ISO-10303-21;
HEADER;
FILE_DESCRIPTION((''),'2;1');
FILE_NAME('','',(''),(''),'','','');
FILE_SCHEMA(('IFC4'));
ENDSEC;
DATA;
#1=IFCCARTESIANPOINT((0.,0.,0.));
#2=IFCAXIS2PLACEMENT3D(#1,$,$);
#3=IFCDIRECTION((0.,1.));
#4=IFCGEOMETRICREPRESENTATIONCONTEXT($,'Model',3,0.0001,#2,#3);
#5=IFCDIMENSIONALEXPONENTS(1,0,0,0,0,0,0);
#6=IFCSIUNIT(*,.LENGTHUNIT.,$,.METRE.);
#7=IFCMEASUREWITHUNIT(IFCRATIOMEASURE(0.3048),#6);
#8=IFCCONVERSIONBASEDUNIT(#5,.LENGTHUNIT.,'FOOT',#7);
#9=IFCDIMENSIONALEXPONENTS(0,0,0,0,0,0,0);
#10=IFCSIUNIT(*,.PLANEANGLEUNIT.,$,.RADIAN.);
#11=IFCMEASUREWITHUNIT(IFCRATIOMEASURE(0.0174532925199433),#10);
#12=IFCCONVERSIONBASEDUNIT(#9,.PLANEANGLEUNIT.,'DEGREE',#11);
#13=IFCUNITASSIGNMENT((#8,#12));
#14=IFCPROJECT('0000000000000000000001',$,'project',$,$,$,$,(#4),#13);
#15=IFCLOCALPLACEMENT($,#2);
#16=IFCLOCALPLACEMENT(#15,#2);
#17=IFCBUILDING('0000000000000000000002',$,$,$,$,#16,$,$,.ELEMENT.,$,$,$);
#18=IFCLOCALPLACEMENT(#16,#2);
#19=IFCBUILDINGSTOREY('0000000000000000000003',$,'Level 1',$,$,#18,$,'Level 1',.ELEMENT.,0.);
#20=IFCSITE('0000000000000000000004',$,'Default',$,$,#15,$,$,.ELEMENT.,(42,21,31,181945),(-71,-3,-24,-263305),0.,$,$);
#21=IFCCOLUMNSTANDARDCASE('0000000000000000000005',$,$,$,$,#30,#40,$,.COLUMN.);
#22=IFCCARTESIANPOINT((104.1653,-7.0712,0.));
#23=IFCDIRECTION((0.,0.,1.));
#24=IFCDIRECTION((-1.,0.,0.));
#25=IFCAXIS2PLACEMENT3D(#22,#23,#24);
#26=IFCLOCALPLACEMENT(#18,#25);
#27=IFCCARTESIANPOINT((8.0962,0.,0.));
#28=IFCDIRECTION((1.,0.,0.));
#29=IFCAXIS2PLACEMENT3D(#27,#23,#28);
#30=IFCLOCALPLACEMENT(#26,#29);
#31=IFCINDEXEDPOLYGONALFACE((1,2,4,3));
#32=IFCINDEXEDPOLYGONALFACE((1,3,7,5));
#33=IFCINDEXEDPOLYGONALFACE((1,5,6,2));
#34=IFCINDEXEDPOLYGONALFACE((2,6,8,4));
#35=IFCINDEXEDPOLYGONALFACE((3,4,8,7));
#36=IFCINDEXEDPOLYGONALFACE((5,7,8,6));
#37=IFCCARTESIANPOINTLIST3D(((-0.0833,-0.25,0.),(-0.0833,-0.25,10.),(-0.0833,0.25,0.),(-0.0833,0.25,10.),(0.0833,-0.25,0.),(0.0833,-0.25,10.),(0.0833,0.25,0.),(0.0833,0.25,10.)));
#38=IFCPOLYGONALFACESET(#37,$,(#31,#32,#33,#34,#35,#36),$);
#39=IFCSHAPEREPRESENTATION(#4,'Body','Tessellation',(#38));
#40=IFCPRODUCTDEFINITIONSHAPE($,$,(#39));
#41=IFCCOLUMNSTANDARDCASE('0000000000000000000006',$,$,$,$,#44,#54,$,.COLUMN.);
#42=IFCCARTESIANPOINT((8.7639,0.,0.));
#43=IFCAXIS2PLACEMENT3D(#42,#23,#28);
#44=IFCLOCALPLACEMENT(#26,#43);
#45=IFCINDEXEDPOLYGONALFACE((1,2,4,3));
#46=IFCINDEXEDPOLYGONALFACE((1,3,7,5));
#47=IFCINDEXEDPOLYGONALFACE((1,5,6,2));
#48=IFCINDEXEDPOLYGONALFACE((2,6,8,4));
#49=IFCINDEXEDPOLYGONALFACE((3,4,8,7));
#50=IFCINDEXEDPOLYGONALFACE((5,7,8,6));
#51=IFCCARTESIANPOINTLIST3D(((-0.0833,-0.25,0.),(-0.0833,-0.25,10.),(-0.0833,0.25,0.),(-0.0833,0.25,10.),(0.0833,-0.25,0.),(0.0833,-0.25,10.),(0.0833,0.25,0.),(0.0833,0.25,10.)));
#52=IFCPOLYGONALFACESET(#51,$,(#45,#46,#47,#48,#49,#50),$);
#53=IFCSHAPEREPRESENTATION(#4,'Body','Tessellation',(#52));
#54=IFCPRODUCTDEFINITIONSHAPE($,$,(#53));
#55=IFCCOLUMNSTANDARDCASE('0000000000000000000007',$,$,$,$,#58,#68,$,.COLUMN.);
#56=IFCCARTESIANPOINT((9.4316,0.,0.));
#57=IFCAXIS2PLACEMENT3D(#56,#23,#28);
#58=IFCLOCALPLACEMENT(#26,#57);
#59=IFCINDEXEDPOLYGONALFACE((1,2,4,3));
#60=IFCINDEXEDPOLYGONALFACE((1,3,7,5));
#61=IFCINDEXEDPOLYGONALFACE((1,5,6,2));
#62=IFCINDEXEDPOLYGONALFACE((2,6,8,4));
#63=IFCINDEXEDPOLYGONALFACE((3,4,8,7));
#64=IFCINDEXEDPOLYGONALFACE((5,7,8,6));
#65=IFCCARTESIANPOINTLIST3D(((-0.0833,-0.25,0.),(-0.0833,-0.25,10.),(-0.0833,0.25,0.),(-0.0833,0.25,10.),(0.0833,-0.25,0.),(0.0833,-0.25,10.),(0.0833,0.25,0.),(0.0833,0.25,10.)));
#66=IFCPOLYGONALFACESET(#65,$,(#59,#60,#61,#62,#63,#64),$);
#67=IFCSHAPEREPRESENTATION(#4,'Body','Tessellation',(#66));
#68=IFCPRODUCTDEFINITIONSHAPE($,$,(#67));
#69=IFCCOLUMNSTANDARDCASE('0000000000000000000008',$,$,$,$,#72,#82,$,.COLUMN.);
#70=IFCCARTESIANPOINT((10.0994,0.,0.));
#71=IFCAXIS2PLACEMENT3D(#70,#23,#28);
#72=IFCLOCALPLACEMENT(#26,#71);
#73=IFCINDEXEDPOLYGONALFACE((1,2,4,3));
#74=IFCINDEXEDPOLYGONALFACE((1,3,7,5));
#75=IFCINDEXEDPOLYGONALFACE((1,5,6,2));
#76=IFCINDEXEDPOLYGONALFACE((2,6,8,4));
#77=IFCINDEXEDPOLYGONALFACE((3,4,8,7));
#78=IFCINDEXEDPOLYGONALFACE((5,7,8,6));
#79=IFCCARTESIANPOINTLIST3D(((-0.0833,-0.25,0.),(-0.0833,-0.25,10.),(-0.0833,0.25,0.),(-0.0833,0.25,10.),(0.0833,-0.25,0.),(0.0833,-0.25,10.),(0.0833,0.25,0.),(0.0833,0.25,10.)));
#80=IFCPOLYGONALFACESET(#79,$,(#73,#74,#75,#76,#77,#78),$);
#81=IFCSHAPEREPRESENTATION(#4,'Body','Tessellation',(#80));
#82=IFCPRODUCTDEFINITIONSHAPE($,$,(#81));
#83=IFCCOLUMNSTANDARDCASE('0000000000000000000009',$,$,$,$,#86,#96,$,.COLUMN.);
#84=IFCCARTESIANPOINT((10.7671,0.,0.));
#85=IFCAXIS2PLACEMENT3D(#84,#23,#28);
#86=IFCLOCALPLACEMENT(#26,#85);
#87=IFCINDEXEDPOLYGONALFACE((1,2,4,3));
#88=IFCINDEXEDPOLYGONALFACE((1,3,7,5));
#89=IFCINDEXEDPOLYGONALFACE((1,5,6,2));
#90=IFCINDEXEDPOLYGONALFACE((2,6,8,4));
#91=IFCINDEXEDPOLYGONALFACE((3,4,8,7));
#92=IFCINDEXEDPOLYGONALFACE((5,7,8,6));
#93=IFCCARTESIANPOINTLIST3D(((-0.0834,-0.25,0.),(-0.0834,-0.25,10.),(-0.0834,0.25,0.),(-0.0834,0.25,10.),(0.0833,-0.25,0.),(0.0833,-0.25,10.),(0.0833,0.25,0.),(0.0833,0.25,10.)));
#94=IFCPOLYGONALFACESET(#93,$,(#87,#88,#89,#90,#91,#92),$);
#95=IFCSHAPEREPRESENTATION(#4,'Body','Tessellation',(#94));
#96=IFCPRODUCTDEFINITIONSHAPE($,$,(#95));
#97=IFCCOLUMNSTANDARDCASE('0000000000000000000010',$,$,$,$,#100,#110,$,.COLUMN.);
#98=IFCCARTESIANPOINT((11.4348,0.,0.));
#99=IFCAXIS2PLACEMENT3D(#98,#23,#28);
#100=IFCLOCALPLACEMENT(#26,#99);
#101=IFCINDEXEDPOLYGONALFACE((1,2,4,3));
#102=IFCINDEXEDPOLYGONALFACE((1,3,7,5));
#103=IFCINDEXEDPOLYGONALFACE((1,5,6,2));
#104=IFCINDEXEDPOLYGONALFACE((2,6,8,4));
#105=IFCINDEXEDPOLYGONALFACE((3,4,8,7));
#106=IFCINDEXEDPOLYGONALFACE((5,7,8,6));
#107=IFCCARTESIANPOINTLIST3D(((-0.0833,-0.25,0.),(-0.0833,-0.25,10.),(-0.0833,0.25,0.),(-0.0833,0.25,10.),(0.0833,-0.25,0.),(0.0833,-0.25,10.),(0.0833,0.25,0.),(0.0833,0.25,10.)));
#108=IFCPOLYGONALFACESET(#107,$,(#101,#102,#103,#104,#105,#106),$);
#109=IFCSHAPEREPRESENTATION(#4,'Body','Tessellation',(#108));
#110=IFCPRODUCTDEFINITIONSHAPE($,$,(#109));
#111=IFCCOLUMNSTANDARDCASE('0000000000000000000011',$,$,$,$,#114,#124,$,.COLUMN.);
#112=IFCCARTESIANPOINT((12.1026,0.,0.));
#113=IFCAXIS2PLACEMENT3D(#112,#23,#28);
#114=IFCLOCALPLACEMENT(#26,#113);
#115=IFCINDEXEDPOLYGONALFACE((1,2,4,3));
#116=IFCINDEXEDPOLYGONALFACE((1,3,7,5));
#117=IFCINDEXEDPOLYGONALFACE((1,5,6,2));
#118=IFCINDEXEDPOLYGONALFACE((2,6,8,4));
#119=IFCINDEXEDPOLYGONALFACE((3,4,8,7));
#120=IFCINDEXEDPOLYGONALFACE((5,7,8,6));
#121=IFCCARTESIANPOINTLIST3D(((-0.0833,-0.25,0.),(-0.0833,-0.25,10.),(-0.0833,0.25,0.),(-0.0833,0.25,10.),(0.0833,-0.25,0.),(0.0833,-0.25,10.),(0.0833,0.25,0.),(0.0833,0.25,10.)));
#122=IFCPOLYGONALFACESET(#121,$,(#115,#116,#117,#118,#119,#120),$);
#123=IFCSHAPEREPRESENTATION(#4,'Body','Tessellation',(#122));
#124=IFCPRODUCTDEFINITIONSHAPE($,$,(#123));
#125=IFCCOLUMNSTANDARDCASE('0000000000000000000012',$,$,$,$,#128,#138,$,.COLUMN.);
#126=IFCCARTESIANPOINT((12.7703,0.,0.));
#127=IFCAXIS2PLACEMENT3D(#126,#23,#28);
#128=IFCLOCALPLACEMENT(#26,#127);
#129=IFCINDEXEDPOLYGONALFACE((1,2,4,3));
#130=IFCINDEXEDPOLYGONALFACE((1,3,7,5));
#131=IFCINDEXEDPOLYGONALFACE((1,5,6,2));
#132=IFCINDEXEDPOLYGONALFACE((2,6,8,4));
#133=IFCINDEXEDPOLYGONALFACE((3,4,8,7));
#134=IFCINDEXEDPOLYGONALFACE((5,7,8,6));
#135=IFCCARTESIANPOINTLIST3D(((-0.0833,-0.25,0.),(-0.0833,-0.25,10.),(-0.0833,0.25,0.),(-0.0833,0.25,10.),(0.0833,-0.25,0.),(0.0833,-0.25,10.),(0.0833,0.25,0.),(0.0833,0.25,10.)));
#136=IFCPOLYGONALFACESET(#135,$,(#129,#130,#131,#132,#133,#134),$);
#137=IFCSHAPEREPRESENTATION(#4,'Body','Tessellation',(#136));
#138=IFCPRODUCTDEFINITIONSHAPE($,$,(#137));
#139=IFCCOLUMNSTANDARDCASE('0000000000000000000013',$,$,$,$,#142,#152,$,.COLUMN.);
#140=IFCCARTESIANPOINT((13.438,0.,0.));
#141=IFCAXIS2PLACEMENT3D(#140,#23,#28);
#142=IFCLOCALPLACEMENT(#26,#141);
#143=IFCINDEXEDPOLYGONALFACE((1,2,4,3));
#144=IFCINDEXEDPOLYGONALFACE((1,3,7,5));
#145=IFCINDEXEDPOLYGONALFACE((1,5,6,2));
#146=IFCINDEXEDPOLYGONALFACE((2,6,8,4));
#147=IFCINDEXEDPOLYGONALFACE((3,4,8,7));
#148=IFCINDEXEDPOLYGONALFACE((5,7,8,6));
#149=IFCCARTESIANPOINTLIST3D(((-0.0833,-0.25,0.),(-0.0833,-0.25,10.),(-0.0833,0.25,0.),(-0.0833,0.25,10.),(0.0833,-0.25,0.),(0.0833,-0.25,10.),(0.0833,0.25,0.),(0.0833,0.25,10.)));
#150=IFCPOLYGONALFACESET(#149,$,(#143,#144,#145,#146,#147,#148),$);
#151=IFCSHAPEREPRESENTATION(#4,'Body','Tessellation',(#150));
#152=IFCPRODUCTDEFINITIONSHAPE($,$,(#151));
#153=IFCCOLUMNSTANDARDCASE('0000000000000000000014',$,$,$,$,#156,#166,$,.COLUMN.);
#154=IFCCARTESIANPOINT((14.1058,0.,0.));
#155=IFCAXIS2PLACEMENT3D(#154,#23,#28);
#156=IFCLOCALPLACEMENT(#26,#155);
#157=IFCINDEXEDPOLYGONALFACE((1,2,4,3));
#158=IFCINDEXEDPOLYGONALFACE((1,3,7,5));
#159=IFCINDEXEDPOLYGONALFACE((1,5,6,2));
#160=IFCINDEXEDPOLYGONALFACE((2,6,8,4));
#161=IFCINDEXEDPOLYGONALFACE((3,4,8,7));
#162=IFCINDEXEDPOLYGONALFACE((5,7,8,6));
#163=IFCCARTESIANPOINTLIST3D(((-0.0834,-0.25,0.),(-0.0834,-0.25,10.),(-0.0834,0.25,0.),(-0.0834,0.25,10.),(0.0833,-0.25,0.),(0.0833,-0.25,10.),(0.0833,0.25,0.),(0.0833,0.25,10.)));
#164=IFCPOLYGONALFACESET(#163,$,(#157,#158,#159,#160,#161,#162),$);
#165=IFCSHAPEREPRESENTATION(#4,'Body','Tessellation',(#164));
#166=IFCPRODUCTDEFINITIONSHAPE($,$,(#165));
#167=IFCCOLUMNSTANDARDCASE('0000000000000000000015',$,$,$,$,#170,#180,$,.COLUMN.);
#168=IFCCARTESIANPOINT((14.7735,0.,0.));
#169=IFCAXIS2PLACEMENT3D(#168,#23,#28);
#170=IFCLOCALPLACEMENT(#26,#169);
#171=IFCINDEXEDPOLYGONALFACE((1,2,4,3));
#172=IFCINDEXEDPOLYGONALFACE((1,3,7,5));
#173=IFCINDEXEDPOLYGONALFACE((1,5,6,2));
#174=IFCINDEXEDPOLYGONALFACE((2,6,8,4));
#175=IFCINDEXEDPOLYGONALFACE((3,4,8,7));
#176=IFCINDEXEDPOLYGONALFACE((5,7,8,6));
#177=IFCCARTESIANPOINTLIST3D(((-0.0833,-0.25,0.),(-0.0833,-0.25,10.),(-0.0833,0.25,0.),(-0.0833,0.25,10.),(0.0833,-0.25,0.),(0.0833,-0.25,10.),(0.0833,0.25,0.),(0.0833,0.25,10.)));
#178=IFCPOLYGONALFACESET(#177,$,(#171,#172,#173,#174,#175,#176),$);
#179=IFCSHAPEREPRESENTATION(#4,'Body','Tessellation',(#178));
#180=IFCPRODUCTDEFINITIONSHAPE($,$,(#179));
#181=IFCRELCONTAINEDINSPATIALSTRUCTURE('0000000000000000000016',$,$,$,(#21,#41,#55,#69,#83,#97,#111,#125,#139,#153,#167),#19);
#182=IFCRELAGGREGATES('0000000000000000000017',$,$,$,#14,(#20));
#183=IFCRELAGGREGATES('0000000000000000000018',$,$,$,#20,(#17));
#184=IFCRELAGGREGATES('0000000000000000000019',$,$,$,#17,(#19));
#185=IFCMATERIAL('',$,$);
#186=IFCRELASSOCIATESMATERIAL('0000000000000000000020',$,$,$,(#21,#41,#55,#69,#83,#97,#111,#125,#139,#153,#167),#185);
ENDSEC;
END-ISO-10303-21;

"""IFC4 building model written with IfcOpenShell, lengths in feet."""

from ifc_helpers import new_model, entity, si_unit, converted_unit, direction, frame, origin, place, context, project, spatial, rectangle, extrude, material, element, save


model = new_model("IFC4")

# Units and contexts
model_context = context("Model", 3, precision=0.0001, world=origin(), true_north=direction((0.0, 1.0)))
ifc_project = project(units=[converted_unit("LENGTHUNIT", "FOOT", entity("IfcRatioMeasure", 0.3048), si_unit("LENGTHUNIT", "METRE"), dimensions=[1, 0, 0, 0, 0, 0, 0]), converted_unit("PLANEANGLEUNIT", "DEGREE", entity("IfcRatioMeasure", 0.0174532925199433), si_unit("PLANEANGLEUNIT", "RADIAN"), dimensions=[0, 0, 0, 0, 0, 0, 0])], contexts=[model_context])

# Site, building, storey
site_placement = place(None, origin())
site = spatial("IfcSite", under=ifc_project, at=site_placement, Name="Default", CompositionType="ELEMENT", RefLatitude=(42, 21, 31, 181945), RefLongitude=(-71, -3, -24, -263305), RefElevation=0.0)
building_placement = place(site_placement, origin())
building = spatial("IfcBuilding", under=site, at=building_placement, CompositionType="ELEMENT")
storey_placement = place(building_placement, origin())
storey = spatial("IfcBuildingStorey", under=building, at=storey_placement, Name="Level 1", LongName="Level 1", CompositionType="ELEMENT", Elevation=0.0)

# Columns
ifc_material = material(Name="")
placement = place(storey_placement, frame((104.1653, -7.0712, 0.0), z_axis=(0.0, 0.0, 1.0), x_axis=(-1.0, 0.0, 0.0)))
for number, where, z_axis, x_axis in (
    (1, (8.0962, 0.0, 0.0), (0.0, 0.0, 1.0), (1.0, 0.0, 0.0)),
    (2, (8.7639, 0.0, 0.0), (0.0, 0.0, 1.0), (1.0, 0.0, 0.0)),
    (3, (9.4316, 0.0, 0.0), (0.0, 0.0, 1.0), (1.0, 0.0, 0.0)),
    (4, (10.0994, 0.0, 0.0), (0.0, 0.0, 1.0), (1.0, 0.0, 0.0)),
    (5, (10.7671, 0.0, 0.0), (0.0, 0.0, 1.0), (1.0, 0.0, 0.0)),
    (6, (11.4348, 0.0, 0.0), (0.0, 0.0, 1.0), (1.0, 0.0, 0.0)),
    (7, (12.1026, 0.0, 0.0), (0.0, 0.0, 1.0), (1.0, 0.0, 0.0)),
    (8, (12.7703, 0.0, 0.0), (0.0, 0.0, 1.0), (1.0, 0.0, 0.0)),
    (9, (13.438, 0.0, 0.0), (0.0, 0.0, 1.0), (1.0, 0.0, 0.0)),
    (10, (14.1058, 0.0, 0.0), (0.0, 0.0, 1.0), (1.0, 0.0, 0.0)),
    (11, (14.7735, 0.0, 0.0), (0.0, 0.0, 1.0), (1.0, 0.0, 0.0)),
):
    element("IfcColumnStandardCase", number, at=place(placement, frame(where, z_axis=z_axis, x_axis=x_axis)), inside=storey, material=ifc_material, PredefinedType="COLUMN", context=model_context, shape_type="SweptSolid", body=[
        extrude(rectangle(XDim=0.1667, YDim=0.5), origin(), (0.0, 0.0, 1.0), 10.0),
    ])

save(model, "model.ifc")
